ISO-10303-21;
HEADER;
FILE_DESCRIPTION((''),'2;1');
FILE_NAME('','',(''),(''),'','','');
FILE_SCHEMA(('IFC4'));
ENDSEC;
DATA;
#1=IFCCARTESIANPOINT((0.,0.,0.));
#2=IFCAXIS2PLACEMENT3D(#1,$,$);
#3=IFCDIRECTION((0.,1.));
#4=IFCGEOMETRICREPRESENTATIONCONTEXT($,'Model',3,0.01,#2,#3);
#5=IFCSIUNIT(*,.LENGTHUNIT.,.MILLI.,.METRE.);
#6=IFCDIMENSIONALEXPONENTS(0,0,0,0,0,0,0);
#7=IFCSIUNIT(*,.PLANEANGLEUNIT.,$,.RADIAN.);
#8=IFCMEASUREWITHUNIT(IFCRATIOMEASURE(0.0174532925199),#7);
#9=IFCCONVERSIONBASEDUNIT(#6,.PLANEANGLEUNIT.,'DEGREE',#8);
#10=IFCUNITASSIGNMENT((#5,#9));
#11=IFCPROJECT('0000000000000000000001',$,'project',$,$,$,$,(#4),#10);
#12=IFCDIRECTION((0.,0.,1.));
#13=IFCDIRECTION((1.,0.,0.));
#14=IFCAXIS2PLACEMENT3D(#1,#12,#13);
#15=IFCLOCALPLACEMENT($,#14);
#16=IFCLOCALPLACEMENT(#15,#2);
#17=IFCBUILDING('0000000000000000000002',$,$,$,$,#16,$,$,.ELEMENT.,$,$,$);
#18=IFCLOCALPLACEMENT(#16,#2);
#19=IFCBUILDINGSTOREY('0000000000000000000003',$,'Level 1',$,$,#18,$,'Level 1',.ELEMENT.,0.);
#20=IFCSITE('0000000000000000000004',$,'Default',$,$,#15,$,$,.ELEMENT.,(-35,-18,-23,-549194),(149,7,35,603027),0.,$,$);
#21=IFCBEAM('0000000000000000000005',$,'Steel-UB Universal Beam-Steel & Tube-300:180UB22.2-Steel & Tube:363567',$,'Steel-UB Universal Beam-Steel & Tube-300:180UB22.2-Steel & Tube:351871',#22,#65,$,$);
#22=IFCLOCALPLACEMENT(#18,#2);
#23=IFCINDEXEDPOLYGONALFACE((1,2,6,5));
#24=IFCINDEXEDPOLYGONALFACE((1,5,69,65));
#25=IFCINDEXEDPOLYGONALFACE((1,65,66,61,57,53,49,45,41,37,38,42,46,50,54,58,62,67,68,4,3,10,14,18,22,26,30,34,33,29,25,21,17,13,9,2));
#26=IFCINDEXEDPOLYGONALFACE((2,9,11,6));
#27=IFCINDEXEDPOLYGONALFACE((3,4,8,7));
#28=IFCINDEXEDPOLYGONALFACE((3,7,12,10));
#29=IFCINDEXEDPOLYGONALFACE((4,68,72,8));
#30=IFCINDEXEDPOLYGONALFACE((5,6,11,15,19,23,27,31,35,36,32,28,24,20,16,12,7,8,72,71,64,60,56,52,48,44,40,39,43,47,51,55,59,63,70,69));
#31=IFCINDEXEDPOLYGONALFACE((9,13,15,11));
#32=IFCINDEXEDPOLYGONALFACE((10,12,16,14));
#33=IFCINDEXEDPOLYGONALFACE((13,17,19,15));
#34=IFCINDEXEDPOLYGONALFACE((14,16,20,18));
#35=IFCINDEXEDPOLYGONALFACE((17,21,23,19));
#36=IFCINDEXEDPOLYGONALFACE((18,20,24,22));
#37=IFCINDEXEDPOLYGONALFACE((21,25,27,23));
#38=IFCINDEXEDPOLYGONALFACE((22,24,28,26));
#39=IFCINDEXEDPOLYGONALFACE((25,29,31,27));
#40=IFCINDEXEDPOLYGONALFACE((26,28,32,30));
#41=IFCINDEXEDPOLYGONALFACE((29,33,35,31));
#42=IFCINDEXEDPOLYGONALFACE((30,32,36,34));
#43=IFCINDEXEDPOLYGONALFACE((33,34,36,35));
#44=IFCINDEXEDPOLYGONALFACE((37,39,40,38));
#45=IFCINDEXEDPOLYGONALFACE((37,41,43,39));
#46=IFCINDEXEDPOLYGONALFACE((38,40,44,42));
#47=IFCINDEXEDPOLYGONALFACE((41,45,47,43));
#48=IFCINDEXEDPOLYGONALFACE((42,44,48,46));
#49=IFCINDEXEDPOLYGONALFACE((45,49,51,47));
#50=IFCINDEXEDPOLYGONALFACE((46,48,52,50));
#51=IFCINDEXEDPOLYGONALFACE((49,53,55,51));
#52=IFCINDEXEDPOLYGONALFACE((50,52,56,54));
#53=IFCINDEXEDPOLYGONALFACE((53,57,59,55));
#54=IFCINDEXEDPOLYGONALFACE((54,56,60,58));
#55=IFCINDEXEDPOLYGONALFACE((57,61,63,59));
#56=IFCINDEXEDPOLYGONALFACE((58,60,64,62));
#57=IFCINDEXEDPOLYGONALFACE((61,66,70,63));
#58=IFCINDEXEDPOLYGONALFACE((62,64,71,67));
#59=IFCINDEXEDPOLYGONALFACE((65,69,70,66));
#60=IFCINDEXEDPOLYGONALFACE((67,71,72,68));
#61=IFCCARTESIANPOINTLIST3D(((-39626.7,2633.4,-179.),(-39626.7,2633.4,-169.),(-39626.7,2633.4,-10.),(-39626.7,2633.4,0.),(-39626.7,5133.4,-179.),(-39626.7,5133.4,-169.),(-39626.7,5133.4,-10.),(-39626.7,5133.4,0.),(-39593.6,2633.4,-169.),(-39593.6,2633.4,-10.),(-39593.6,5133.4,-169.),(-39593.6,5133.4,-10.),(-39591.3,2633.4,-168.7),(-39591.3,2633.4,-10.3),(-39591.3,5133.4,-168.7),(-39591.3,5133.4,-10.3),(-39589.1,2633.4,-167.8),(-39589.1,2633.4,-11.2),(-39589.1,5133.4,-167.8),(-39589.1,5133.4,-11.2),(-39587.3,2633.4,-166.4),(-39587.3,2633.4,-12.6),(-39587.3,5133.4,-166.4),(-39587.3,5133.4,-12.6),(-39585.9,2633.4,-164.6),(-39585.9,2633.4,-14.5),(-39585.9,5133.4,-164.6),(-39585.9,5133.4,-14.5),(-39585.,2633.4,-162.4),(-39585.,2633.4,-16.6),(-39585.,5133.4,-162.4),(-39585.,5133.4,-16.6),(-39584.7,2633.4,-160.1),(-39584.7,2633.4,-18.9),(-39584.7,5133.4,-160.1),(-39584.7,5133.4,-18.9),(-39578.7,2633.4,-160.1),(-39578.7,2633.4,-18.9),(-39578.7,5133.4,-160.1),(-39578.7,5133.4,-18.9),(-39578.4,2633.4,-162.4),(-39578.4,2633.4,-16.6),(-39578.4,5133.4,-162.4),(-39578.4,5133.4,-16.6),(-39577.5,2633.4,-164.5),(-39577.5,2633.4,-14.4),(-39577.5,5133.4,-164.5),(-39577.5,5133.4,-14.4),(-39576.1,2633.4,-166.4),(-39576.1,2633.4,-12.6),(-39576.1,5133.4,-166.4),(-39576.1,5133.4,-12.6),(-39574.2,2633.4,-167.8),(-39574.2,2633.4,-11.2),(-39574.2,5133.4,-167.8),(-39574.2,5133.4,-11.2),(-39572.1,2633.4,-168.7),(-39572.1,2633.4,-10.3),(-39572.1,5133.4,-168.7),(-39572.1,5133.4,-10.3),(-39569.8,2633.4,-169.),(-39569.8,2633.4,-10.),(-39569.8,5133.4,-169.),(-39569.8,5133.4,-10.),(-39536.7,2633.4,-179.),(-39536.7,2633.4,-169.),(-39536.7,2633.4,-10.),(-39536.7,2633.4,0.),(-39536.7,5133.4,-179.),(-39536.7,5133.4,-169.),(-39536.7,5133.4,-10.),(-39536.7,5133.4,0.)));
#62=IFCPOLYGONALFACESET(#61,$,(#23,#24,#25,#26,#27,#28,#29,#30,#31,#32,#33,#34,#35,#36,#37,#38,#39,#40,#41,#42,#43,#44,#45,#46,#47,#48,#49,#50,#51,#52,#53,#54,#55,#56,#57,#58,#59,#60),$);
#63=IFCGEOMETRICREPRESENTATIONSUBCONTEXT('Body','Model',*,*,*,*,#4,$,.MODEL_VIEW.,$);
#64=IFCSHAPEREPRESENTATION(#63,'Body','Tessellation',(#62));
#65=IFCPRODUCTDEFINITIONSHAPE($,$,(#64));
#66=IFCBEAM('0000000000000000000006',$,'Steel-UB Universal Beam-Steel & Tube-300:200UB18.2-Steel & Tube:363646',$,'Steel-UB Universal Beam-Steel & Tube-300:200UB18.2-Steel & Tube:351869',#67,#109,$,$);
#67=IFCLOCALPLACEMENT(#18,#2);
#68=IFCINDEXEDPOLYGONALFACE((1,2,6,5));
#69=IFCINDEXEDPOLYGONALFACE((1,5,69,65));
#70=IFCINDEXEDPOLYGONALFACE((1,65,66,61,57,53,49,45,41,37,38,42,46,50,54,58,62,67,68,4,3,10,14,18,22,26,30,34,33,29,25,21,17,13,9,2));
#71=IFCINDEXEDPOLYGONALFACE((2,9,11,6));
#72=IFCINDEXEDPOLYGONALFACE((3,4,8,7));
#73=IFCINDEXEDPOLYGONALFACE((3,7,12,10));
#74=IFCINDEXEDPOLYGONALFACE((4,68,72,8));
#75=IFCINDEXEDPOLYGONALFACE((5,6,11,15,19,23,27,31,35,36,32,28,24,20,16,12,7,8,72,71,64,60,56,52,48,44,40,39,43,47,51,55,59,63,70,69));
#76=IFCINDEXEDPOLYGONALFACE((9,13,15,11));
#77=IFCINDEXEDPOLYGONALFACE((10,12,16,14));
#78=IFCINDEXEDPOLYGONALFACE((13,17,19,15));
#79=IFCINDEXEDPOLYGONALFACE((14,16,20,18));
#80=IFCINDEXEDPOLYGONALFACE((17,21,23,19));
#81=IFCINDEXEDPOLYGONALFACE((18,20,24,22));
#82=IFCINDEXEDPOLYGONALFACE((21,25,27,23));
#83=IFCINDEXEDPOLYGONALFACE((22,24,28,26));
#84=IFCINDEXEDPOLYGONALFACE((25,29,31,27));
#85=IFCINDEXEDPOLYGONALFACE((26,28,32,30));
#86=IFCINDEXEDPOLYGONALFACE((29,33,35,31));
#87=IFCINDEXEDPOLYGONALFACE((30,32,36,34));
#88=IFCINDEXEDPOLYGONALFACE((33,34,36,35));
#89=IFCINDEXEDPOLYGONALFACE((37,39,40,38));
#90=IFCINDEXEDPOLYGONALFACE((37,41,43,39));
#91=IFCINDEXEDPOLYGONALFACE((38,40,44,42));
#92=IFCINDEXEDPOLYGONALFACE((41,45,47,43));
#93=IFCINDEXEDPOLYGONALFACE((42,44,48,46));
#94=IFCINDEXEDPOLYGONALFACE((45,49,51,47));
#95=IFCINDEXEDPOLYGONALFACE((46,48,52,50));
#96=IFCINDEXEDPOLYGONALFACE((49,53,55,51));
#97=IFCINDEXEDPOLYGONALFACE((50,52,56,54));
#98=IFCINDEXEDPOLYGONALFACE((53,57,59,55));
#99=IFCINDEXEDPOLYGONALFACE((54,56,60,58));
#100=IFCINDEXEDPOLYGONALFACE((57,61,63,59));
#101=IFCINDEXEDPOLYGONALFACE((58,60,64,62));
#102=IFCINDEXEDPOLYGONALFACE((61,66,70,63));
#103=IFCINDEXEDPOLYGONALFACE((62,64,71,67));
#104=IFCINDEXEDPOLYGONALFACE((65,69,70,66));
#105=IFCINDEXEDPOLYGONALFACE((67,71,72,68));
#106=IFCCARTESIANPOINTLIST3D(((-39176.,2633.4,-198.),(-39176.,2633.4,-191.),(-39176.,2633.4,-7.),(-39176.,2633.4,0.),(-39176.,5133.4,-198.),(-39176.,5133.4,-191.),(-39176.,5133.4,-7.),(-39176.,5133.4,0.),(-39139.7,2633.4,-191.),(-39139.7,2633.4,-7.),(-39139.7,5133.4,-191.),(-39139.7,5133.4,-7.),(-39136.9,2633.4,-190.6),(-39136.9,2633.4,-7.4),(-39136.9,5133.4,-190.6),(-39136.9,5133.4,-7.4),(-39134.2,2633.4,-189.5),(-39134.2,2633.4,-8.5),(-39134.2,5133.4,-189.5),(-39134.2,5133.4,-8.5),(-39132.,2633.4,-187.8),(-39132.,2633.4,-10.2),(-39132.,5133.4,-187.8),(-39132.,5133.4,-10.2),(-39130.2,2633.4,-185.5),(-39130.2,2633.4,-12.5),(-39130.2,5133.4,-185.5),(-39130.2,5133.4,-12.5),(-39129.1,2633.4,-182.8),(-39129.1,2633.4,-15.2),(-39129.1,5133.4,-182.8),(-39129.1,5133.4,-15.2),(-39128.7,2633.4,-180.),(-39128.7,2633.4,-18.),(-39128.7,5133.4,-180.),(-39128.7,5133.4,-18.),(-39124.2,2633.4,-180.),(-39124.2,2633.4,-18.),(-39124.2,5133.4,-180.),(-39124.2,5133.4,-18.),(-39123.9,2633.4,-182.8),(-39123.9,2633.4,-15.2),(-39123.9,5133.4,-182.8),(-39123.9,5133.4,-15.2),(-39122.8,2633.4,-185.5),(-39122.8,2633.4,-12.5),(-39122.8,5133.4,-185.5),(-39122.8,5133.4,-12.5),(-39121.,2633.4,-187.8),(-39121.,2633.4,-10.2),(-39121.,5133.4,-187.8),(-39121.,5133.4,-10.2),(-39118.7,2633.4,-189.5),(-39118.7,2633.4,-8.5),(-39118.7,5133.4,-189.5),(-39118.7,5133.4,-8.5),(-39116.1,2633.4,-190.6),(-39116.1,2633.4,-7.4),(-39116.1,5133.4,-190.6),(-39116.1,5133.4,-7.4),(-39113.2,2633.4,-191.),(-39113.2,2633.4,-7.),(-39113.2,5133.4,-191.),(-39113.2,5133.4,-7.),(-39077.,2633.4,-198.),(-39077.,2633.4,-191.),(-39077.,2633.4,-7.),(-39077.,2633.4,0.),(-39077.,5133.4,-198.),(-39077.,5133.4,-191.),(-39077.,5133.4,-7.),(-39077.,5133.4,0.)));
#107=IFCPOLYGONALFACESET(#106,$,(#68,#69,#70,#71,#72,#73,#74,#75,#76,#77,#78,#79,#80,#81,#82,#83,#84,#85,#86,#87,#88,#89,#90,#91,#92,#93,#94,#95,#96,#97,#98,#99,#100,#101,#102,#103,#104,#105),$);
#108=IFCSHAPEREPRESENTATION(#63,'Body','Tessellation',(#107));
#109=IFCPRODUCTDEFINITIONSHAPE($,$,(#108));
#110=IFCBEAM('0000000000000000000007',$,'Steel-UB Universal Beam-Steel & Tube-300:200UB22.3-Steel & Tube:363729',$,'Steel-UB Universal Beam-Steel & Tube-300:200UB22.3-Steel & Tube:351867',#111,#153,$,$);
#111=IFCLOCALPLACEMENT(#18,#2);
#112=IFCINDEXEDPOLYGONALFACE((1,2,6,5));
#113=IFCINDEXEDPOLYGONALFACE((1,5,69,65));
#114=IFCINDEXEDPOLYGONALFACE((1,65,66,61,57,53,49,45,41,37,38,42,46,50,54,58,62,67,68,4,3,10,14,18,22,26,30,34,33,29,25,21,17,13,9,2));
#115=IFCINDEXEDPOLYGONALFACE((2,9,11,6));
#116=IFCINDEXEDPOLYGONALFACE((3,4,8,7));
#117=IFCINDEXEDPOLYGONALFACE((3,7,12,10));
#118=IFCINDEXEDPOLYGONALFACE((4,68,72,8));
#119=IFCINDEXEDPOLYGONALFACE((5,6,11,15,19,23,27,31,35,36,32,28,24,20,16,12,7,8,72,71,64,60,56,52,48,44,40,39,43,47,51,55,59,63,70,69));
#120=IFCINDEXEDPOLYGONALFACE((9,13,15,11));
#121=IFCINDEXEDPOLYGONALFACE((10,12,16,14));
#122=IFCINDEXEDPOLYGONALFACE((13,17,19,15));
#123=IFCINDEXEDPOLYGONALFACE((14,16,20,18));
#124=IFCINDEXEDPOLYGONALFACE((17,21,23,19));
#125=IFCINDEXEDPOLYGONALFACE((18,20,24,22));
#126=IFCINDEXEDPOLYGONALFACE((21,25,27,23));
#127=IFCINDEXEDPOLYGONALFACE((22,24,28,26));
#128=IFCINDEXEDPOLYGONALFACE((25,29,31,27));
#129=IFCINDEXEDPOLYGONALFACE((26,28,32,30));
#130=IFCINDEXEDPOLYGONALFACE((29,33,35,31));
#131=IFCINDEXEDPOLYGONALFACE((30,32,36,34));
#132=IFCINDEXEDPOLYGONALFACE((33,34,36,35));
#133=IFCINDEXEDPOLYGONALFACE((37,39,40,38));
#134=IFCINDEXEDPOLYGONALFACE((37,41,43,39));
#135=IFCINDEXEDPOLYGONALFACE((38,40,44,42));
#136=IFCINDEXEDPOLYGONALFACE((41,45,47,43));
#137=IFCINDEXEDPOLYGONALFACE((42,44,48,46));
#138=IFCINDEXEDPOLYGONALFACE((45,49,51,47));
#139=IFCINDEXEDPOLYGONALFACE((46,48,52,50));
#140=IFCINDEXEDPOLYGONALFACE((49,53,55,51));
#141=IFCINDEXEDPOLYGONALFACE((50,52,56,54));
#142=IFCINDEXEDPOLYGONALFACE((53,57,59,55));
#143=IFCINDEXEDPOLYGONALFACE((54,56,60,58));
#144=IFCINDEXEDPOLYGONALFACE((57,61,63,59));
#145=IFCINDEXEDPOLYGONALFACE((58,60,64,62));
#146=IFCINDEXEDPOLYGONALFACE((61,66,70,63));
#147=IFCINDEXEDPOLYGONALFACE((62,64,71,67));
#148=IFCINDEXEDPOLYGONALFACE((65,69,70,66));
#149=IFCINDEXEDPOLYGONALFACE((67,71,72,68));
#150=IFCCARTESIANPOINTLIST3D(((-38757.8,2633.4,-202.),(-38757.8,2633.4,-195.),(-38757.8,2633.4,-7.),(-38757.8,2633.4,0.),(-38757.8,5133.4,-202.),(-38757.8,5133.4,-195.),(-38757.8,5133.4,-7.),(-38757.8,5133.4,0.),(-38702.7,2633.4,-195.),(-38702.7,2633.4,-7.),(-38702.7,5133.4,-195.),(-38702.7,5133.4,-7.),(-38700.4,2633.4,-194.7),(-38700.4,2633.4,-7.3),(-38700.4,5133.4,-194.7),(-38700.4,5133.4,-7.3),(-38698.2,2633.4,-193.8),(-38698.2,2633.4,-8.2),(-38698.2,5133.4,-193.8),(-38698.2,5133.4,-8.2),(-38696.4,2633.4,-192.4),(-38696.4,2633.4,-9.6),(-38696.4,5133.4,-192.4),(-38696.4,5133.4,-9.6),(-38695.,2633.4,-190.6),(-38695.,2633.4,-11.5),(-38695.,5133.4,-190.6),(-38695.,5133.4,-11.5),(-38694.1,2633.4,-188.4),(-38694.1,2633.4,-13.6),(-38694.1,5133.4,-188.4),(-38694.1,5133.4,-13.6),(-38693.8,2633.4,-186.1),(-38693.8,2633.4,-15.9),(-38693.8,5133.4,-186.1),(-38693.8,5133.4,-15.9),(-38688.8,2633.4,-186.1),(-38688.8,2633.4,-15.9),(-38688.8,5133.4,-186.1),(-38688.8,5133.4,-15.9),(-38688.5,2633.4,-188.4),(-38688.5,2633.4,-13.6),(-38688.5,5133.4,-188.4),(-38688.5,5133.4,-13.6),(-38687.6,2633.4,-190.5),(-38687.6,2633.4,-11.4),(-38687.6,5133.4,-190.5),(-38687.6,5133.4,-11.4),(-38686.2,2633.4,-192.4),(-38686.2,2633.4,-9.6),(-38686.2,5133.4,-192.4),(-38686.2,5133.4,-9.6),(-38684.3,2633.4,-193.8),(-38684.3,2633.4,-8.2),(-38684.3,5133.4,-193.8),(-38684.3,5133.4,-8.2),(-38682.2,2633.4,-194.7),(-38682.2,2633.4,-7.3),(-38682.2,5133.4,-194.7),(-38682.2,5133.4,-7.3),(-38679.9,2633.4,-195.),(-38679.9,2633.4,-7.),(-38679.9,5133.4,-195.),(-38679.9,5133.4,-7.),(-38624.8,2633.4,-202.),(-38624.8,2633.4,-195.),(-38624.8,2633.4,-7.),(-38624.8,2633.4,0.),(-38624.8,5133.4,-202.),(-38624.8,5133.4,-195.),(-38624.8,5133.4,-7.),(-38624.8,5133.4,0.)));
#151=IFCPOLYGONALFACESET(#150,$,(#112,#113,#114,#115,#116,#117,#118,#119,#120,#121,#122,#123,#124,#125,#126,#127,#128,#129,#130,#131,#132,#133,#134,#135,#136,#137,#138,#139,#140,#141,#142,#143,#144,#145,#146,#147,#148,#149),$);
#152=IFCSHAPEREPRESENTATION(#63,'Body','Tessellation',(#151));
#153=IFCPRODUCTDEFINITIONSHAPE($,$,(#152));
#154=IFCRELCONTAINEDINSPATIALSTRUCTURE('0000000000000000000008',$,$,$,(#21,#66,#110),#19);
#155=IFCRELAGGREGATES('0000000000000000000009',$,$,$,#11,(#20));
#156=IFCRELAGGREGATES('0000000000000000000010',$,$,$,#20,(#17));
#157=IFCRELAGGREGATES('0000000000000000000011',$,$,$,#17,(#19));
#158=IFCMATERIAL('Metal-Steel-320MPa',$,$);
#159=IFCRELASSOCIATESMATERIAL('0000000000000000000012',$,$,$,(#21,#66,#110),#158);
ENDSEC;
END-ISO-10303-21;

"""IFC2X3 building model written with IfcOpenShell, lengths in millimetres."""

from ifc_helpers import new_model, entity, si_unit, converted_unit, direction, frame, frame_2d, origin, origin_with_axes, place, context, subcontext, project, spatial, polyline, circle_curve, parameter, trimmed, segment, composite_curve, outline, extrude, material, element, save


model = new_model("IFC2X3")

# Units and contexts
model_context = context("Model", 3, precision=0.01, world=origin(), true_north=direction((0.0, 1.0)))
body_context = subcontext(model_context, "Body", "Model", "MODEL_VIEW")
ifc_project = project(units=[si_unit("LENGTHUNIT", "METRE", prefix="MILLI"), converted_unit("PLANEANGLEUNIT", "DEGREE", entity("IfcRatioMeasure", 0.0174532925199), si_unit("PLANEANGLEUNIT", "RADIAN"), dimensions=[0, 0, 0, 0, 0, 0, 0])], contexts=[model_context])

# Site, building, storey
site_placement = place(None, origin_with_axes())
site = spatial("IfcSite", under=ifc_project, at=site_placement, Name="Default", CompositionType="ELEMENT", RefLatitude=(-35, -18, -23, -549194), RefLongitude=(149, 7, 35, 603027), RefElevation=0.0)
building_placement = place(site_placement, origin())
building = spatial("IfcBuilding", under=site, at=building_placement, CompositionType="ELEMENT")
storey_placement = place(building_placement, origin())
storey = spatial("IfcBuildingStorey", under=building, at=storey_placement, Name="Level 1", LongName="Level 1", CompositionType="ELEMENT", Elevation=0.0)

# Beams
ifc_material = material(Name="Metal-Steel-320MPa")
beam_1_placement = place(storey_placement, frame((-39581.7, 5133.4, 0.0), z_axis=(0.0, 0.0, 1.0), x_axis=(0.0, -1.0, 0.0)))
element("IfcBeam", 1, at=beam_1_placement, inside=storey, material=ifc_material, Name="Steel-UB Universal Beam-Steel & Tube-300:180UB22.2-Steel & Tube:363567", ObjectType="Steel-UB Universal Beam-Steel & Tube-300:180UB22.2-Steel & Tube:351871", context=body_context, shape_type="SweptSolid", body=[
    extrude(outline(composite_curve([segment(polyline([(79.5, -45.0), (89.5, -45.0)]), True, "CONTINUOUS"), segment(polyline([(89.5, -45.0), (89.5, 45.0)]), True, "CONTINUOUS"), segment(polyline([(89.5, 45.0), (79.5, 45.0)]), True, "CONTINUOUS"), segment(polyline([(79.5, 45.0), (79.5, 11.9)]), True, "CONTINUOUS"), segment(trimmed(circle_curve(frame_2d((70.6, 11.9), x_axis=(1.0, 0.0)), 8.9), [parameter(270.0)], [parameter(0.0)], True, "PARAMETER"), False, "CONTINUOUS"), segment(polyline([(70.6, 3.0), (-70.6, 3.0)]), True, "CONTINUOUS"), segment(trimmed(circle_curve(frame_2d((-70.6, 11.9), x_axis=(0.0, -1.0)), 8.9), [parameter(270.0)], [parameter(0.0)], True, "PARAMETER"), False, "CONTINUOUS"), segment(polyline([(-79.5, 11.9), (-79.5, 45.0)]), True, "CONTINUOUS"), segment(polyline([(-79.5, 45.0), (-89.5, 45.0)]), True, "CONTINUOUS"), segment(polyline([(-89.5, 45.0), (-89.5, -45.0)]), True, "CONTINUOUS"), segment(polyline([(-89.5, -45.0), (-79.5, -45.0)]), True, "CONTINUOUS"), segment(polyline([(-79.5, -45.0), (-79.5, -11.9)]), True, "CONTINUOUS"), segment(trimmed(circle_curve(frame_2d((-70.6, -11.9), x_axis=(-1.0, 0.0)), 8.9), [parameter(270.0)], [parameter(0.0)], True, "PARAMETER"), False, "CONTINUOUS"), segment(polyline([(-70.6, -3.0), (70.6, -3.0)]), True, "CONTINUOUS"), segment(trimmed(circle_curve(frame_2d((70.6, -11.9), x_axis=(0.0, 1.0)), 8.9), [parameter(270.0)], [parameter(0.0)], True, "PARAMETER"), False, "CONTINUOUS"), segment(polyline([(79.5, -11.9), (79.5, -45.0)]), True, "CONTINUOUS")], self_intersect=False)), frame((0.0, 0.0, -89.5), z_axis=(1.0, 0.0, 0.0), x_axis=(0.0, 0.0, -1.0)), (0.0, 0.0, 1.0), 2500.0),
])
beam_2_placement = place(storey_placement, frame((-39126.5, 5133.4, 0.0), z_axis=(0.0, 0.0, 1.0), x_axis=(0.0, -1.0, 0.0)))
element("IfcBeam", 2, at=beam_2_placement, inside=storey, material=ifc_material, Name="Steel-UB Universal Beam-Steel & Tube-300:200UB18.2-Steel & Tube:363646", ObjectType="Steel-UB Universal Beam-Steel & Tube-300:200UB18.2-Steel & Tube:351869", context=body_context, shape_type="SweptSolid", body=[
    extrude(outline(composite_curve([segment(polyline([(92.0, -49.5), (99.0, -49.5)]), True, "CONTINUOUS"), segment(polyline([(99.0, -49.5), (99.0, 49.5)]), True, "CONTINUOUS"), segment(polyline([(99.0, 49.5), (92.0, 49.5)]), True, "CONTINUOUS"), segment(polyline([(92.0, 49.5), (92.0, 13.2)]), True, "CONTINUOUS"), segment(trimmed(circle_curve(frame_2d((81.0, 13.2), x_axis=(1.0, 0.0)), 11.0), [parameter(270.0)], [parameter(0.0)], True, "PARAMETER"), False, "CONTINUOUS"), segment(polyline([(81.0, 2.2), (-81.0, 2.2)]), True, "CONTINUOUS"), segment(trimmed(circle_curve(frame_2d((-81.0, 13.2), x_axis=(0.0, -1.0)), 11.0), [parameter(270.0)], [parameter(0.0)], True, "PARAMETER"), False, "CONTINUOUS"), segment(polyline([(-92.0, 13.2), (-92.0, 49.5)]), True, "CONTINUOUS"), segment(polyline([(-92.0, 49.5), (-99.0, 49.5)]), True, "CONTINUOUS"), segment(polyline([(-99.0, 49.5), (-99.0, -49.5)]), True, "CONTINUOUS"), segment(polyline([(-99.0, -49.5), (-92.0, -49.5)]), True, "CONTINUOUS"), segment(polyline([(-92.0, -49.5), (-92.0, -13.2)]), True, "CONTINUOUS"), segment(trimmed(circle_curve(frame_2d((-81.0, -13.2), x_axis=(-1.0, 0.0)), 11.0), [parameter(270.0)], [parameter(0.0)], True, "PARAMETER"), False, "CONTINUOUS"), segment(polyline([(-81.0, -2.2), (81.0, -2.2)]), True, "CONTINUOUS"), segment(trimmed(circle_curve(frame_2d((81.0, -13.2), x_axis=(0.0, 1.0)), 11.0), [parameter(270.0)], [parameter(0.0)], True, "PARAMETER"), False, "CONTINUOUS"), segment(polyline([(92.0, -13.2), (92.0, -49.5)]), True, "CONTINUOUS")], self_intersect=False)), frame((0.0, 0.0, -99.0), z_axis=(1.0, 0.0, 0.0), x_axis=(0.0, 0.0, -1.0)), (0.0, 0.0, 1.0), 2500.0),
])
beam_3_placement = place(storey_placement, frame((-38691.3, 5133.4, 0.0), z_axis=(0.0, 0.0, 1.0), x_axis=(0.0, -1.0, 0.0)))
element("IfcBeam", 3, at=beam_3_placement, inside=storey, material=ifc_material, Name="Steel-UB Universal Beam-Steel & Tube-300:200UB22.3-Steel & Tube:363729", ObjectType="Steel-UB Universal Beam-Steel & Tube-300:200UB22.3-Steel & Tube:351867", context=body_context, shape_type="SweptSolid", body=[
    extrude(outline(composite_curve([segment(polyline([(94.0, -66.5), (101.0, -66.5)]), True, "CONTINUOUS"), segment(polyline([(101.0, -66.5), (101.0, 66.5)]), True, "CONTINUOUS"), segment(polyline([(101.0, 66.5), (94.0, 66.5)]), True, "CONTINUOUS"), segment(polyline([(94.0, 66.5), (94.0, 11.4)]), True, "CONTINUOUS"), segment(trimmed(circle_curve(frame_2d((85.1, 11.4), x_axis=(1.0, 0.0)), 8.9), [parameter(270.0)], [parameter(0.0)], True, "PARAMETER"), False, "CONTINUOUS"), segment(polyline([(85.1, 2.5), (-85.1, 2.5)]), True, "CONTINUOUS"), segment(trimmed(circle_curve(frame_2d((-85.1, 11.4), x_axis=(0.0, -1.0)), 8.9), [parameter(270.0)], [parameter(0.0)], True, "PARAMETER"), False, "CONTINUOUS"), segment(polyline([(-94.0, 11.4), (-94.0, 66.5)]), True, "CONTINUOUS"), segment(polyline([(-94.0, 66.5), (-101.0, 66.5)]), True, "CONTINUOUS"), segment(polyline([(-101.0, 66.5), (-101.0, -66.5)]), True, "CONTINUOUS"), segment(polyline([(-101.0, -66.5), (-94.0, -66.5)]), True, "CONTINUOUS"), segment(polyline([(-94.0, -66.5), (-94.0, -11.4)]), True, "CONTINUOUS"), segment(trimmed(circle_curve(frame_2d((-85.1, -11.4), x_axis=(-1.0, 0.0)), 8.9), [parameter(270.0)], [parameter(0.0)], True, "PARAMETER"), False, "CONTINUOUS"), segment(polyline([(-85.1, -2.5), (85.1, -2.5)]), True, "CONTINUOUS"), segment(trimmed(circle_curve(frame_2d((85.1, -11.4), x_axis=(0.0, 1.0)), 8.9), [parameter(270.0)], [parameter(0.0)], True, "PARAMETER"), False, "CONTINUOUS"), segment(polyline([(94.0, -11.4), (94.0, -66.5)]), True, "CONTINUOUS")], self_intersect=False)), frame((0.0, 0.0, -101.0), z_axis=(1.0, 0.0, 0.0), x_axis=(0.0, 0.0, -1.0)), (0.0, 0.0, 1.0), 2500.0),
])

save(model, "model.ifc")
